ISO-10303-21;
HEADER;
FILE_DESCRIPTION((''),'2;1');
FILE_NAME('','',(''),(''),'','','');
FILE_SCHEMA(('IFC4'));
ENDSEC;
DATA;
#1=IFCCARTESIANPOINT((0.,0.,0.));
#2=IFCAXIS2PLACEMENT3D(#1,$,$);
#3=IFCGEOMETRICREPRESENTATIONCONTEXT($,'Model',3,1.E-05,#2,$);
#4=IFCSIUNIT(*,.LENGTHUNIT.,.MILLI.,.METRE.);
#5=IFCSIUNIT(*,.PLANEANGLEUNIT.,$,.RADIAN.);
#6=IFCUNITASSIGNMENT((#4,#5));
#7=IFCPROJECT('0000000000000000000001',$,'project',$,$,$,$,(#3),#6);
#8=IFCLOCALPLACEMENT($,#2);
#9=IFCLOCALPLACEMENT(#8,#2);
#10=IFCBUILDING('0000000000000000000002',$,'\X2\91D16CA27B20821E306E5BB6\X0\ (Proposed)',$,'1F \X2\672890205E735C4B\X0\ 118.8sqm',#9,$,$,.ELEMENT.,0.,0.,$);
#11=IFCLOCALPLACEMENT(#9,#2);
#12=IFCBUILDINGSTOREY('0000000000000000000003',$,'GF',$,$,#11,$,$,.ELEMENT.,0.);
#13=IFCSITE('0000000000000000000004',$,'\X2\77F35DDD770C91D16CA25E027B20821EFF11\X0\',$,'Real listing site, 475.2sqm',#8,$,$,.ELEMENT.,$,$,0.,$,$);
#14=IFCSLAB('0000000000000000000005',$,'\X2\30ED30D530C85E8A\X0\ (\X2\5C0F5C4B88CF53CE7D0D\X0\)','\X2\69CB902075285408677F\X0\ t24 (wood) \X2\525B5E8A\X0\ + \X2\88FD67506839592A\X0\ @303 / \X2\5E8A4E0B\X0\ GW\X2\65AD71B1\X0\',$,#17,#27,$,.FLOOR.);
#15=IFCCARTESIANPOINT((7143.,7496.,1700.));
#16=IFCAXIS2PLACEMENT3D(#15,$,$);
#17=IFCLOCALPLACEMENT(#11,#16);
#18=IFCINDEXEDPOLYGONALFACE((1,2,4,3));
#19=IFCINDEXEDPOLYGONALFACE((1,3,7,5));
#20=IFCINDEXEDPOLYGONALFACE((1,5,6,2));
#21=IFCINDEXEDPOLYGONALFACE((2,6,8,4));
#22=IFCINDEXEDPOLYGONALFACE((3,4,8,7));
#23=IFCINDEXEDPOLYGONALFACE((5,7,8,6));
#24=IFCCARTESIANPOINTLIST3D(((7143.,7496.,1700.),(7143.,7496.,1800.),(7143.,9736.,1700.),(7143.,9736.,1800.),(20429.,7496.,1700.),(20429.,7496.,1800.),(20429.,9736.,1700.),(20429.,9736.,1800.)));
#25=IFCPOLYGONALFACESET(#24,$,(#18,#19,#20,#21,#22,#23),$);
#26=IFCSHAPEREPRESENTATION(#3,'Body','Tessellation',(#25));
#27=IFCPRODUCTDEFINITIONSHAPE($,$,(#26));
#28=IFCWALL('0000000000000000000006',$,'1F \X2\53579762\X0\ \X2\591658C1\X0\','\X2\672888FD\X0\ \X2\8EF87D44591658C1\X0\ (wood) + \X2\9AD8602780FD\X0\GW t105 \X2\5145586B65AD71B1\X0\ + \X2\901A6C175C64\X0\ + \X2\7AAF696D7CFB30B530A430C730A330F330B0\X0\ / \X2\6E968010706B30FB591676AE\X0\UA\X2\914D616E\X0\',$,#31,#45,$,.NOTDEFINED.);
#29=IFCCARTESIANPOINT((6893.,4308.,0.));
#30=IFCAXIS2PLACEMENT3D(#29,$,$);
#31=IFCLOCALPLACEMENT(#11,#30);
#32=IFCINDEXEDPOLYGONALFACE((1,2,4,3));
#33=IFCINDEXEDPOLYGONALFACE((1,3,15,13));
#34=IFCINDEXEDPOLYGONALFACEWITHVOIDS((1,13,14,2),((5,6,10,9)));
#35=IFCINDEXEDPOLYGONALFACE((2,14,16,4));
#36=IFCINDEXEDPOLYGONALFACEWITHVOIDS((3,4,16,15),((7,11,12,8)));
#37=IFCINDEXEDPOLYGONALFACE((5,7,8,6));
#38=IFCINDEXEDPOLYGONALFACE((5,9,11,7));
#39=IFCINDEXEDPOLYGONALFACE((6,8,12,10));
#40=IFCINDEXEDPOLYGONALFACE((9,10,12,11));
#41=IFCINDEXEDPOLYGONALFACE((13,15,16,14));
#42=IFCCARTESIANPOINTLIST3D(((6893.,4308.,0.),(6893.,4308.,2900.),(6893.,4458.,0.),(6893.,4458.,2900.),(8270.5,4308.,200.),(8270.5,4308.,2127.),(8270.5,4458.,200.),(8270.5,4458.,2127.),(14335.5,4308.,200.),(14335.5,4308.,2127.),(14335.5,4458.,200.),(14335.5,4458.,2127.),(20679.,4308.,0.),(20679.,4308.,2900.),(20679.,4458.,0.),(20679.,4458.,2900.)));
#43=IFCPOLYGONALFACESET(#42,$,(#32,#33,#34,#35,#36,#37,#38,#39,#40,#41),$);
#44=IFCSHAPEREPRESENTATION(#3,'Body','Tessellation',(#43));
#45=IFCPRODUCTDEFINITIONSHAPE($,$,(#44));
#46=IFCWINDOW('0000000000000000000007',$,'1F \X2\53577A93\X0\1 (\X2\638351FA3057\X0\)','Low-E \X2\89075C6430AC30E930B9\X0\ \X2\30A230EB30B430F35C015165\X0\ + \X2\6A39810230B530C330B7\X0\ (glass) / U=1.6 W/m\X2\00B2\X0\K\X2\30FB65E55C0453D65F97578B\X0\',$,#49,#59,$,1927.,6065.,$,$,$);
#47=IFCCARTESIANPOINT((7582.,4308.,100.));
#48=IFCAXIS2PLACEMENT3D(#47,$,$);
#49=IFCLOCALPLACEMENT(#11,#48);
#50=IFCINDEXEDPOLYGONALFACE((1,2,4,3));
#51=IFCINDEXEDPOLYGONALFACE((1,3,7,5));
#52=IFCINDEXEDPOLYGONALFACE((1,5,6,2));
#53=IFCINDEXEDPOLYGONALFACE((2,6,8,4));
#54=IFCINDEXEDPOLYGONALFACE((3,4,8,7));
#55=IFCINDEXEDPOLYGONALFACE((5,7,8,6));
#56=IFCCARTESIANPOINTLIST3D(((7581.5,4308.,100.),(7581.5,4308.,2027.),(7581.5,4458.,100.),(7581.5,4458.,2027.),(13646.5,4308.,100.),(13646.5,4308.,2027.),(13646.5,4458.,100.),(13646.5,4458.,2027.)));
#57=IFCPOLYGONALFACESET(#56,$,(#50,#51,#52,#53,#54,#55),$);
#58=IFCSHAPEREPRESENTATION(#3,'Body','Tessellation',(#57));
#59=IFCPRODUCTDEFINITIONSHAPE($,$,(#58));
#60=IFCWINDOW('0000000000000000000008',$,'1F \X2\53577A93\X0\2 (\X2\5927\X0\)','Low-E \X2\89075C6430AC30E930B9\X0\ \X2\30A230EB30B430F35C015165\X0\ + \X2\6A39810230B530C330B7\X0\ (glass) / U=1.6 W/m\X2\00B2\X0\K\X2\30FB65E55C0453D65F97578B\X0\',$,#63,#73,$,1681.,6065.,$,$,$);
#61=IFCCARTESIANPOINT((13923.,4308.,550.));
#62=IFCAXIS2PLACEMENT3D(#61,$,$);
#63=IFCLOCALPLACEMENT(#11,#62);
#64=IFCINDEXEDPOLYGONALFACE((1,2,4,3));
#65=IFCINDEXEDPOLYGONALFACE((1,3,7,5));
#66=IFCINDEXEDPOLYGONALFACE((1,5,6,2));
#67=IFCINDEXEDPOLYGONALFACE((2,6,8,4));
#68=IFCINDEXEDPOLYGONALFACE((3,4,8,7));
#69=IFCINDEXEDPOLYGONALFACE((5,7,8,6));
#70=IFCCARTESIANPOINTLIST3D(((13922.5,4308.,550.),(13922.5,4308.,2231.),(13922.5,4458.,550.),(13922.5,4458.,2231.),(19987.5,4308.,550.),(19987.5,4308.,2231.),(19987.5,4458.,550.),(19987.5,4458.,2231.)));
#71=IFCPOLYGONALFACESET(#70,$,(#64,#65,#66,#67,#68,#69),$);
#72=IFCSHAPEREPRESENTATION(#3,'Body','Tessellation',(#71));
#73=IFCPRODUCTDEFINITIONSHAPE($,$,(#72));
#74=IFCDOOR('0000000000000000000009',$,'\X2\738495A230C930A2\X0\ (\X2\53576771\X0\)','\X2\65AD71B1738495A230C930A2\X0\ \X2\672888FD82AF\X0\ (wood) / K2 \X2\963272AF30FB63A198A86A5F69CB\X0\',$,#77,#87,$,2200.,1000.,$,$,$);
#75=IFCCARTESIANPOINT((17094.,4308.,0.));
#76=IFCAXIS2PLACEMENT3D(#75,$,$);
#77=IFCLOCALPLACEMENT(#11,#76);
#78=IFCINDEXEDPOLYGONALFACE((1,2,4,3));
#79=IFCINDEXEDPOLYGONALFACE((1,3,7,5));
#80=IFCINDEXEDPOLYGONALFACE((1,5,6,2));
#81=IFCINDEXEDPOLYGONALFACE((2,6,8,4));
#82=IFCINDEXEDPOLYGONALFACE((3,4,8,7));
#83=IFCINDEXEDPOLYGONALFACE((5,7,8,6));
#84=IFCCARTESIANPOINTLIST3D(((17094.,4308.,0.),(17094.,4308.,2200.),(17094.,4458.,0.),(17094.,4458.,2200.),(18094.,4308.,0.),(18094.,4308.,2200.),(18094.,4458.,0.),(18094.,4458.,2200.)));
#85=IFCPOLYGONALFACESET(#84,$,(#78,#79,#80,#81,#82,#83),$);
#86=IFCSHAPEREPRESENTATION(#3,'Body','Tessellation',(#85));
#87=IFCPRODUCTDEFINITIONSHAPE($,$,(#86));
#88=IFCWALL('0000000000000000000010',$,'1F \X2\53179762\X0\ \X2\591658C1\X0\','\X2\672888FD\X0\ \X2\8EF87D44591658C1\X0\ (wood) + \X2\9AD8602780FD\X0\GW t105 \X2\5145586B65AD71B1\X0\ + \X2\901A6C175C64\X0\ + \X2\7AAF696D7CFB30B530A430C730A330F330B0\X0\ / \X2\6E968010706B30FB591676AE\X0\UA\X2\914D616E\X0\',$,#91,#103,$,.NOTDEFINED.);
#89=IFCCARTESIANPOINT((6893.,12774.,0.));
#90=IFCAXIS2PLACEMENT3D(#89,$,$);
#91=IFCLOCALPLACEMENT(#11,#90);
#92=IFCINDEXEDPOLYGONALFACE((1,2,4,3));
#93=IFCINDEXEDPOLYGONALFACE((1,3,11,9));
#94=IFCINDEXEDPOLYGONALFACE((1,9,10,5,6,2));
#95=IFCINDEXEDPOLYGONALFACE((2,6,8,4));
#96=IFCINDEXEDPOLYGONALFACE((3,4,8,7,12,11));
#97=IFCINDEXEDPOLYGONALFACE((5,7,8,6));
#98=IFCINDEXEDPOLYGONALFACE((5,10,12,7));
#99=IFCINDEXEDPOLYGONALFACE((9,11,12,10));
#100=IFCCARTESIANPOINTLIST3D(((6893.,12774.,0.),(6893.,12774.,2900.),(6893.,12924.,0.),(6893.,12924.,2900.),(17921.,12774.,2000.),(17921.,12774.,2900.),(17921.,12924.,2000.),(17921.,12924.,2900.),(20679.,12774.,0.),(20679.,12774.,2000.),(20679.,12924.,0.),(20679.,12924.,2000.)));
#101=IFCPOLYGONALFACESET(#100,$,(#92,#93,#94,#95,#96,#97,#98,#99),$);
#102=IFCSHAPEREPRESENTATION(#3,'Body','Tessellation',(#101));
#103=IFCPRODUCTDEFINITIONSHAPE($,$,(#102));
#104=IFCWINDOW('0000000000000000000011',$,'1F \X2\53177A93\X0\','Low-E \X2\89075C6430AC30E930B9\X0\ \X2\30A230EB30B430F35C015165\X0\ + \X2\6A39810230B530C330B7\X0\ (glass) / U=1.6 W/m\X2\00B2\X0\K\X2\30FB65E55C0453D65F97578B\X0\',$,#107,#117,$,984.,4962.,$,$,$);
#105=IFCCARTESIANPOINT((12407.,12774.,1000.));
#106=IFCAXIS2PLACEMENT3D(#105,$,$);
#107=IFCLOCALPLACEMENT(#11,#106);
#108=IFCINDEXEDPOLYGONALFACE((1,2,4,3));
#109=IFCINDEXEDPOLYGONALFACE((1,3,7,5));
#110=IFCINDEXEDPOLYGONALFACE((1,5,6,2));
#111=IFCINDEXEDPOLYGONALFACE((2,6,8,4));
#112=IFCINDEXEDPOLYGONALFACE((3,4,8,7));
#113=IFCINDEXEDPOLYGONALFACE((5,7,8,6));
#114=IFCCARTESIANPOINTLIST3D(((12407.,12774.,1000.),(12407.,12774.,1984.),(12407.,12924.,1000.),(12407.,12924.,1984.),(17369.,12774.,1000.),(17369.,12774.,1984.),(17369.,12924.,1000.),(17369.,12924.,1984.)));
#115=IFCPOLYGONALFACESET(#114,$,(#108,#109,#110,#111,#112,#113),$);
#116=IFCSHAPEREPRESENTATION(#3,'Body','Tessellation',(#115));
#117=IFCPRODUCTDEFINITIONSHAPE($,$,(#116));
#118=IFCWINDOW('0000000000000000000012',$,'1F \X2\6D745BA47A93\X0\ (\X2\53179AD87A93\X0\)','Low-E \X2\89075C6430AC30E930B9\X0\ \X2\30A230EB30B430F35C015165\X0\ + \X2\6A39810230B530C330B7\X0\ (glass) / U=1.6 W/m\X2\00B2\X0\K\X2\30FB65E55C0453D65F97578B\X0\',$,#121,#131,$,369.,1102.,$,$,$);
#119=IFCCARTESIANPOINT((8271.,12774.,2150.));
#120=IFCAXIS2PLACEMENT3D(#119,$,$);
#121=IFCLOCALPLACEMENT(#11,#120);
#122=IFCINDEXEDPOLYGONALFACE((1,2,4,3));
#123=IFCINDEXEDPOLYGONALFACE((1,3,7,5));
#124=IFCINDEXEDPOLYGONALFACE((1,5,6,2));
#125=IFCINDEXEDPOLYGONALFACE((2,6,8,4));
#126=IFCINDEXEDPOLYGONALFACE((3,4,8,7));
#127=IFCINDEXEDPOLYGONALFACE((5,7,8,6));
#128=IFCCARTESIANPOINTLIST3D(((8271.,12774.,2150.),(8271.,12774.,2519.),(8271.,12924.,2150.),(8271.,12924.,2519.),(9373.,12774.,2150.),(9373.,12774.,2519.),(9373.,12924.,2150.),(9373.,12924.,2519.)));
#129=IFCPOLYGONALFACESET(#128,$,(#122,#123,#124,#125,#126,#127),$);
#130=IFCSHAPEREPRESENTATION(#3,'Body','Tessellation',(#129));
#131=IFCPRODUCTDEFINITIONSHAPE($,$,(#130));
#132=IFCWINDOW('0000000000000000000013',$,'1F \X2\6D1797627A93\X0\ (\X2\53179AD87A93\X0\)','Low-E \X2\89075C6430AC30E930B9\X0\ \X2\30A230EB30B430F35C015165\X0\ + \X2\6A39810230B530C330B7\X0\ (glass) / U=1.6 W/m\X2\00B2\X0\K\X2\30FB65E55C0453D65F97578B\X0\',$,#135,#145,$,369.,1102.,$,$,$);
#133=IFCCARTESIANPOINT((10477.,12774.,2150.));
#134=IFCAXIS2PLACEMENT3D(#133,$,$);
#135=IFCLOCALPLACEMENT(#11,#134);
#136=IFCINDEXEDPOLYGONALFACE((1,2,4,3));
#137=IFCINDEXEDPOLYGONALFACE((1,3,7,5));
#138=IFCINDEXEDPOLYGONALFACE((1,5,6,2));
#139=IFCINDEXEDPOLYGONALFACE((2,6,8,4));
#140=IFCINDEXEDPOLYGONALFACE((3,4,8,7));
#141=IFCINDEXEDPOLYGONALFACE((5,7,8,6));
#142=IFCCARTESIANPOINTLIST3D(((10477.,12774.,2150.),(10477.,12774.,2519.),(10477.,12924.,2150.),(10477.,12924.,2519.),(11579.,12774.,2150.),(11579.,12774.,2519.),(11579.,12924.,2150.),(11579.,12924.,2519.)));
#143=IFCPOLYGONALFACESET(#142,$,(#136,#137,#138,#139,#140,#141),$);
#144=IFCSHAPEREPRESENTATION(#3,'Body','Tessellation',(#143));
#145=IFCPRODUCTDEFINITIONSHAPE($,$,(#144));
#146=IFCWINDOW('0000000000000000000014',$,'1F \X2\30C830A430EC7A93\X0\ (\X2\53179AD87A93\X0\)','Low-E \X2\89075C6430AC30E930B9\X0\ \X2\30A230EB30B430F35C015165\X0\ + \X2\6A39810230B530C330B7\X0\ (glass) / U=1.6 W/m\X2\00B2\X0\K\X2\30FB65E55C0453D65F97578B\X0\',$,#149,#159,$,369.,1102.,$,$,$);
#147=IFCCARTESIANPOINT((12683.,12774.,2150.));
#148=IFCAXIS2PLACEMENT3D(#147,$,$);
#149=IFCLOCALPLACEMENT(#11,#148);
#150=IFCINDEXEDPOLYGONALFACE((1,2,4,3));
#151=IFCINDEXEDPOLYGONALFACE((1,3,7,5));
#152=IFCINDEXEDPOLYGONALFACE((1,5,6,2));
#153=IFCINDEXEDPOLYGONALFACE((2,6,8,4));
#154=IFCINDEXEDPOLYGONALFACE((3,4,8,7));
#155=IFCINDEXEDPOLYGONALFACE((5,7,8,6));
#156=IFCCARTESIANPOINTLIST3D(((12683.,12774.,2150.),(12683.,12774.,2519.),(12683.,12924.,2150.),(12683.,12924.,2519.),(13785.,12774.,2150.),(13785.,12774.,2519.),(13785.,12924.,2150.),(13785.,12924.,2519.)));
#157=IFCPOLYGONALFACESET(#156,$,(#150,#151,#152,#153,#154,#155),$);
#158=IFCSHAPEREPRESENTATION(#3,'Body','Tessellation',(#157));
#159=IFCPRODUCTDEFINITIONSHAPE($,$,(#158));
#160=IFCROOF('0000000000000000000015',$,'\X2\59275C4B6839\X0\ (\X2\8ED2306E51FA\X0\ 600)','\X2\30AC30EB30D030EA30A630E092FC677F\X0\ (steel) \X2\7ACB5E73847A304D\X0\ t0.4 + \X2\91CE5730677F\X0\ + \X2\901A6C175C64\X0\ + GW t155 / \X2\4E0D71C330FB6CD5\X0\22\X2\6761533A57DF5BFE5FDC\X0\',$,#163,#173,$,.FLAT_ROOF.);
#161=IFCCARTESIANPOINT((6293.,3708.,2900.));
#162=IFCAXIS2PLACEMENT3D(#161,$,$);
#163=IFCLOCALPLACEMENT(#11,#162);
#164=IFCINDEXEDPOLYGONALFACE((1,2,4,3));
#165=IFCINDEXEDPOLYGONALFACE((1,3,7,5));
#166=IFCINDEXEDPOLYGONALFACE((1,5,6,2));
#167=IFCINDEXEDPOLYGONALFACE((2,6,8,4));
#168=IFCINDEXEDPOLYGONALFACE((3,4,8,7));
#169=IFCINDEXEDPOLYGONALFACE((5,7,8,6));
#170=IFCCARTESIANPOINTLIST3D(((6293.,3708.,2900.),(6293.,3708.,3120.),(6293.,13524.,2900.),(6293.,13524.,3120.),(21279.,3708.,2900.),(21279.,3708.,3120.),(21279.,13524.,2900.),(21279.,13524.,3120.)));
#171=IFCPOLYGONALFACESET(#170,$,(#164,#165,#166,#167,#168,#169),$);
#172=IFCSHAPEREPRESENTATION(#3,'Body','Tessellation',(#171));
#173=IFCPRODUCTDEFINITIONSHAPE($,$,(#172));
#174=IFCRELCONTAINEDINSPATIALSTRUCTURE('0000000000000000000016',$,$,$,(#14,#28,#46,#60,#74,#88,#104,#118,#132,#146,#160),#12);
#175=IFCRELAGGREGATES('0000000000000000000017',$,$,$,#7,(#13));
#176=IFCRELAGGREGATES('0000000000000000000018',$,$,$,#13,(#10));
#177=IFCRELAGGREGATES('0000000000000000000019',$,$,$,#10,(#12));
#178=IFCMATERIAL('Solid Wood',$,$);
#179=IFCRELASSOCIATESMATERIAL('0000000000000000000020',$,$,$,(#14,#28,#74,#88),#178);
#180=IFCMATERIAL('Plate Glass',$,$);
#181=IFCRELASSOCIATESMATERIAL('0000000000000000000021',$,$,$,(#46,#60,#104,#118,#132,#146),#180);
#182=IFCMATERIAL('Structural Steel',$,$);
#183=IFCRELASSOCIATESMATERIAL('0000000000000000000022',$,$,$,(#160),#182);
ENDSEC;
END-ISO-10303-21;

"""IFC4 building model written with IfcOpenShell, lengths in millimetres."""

from ifc_helpers import new_model, si_unit, frame, frame_2d, origin, place, context, project, spatial, rectangle, extrude, material, element, fill, save


model = new_model("IFC4")

# Units and contexts
model_context = context("Model", 3, precision=1e-05, world=origin())
ifc_project = project(units=[si_unit("LENGTHUNIT", "METRE", prefix="MILLI"), si_unit("PLANEANGLEUNIT", "RADIAN")], contexts=[model_context])

# Site, building, storey
site_placement = place(None, origin())
site = spatial("IfcSite", under=ifc_project, at=site_placement, Name="石川県金沢市笠舞１", ObjectType="Real listing site, 475.2sqm", CompositionType="ELEMENT", RefElevation=0.0)
building_placement = place(site_placement, origin())
building = spatial("IfcBuilding", under=site, at=building_placement, Name="金沢笠舞の家 (Proposed)", ObjectType="1F 木造平屋 118.8sqm", CompositionType="ELEMENT", ElevationOfRefHeight=0.0, ElevationOfTerrain=0.0)
storey_placement = place(building_placement, origin())
storey = spatial("IfcBuildingStorey", under=building, at=storey_placement, Name="GF", CompositionType="ELEMENT", Elevation=0.0)

# Slab
ifc_material_1 = material(Name="Solid Wood")
slab_1_placement = place(storey_placement, frame((7143.0, 7496.0, 1700.0)))
element("IfcSlab", 1, at=slab_1_placement, inside=storey, material=ifc_material_1, Name="ロフト床 (小屋裏収納)", Description="構造用合板 t24 (wood) 剛床 + 製材根太 @303 / 床下 GW断熱", PredefinedType="FLOOR", context=model_context, shape_type="SweptSolid", body=[
    extrude(rectangle(XDim=13286.0, YDim=2240.0, at=frame_2d((6643.0, 1120.0))), frame((7143.0, 7496.0, 1700.0)), (0.0, 0.0, 1.0), 100.0),
])

# Wall, openings, windows, door
wall_1_placement = place(storey_placement, frame((6893.0, 4308.0, 0.0)))
wall_1 = element("IfcWall", 2, at=wall_1_placement, inside=storey, material=ifc_material_1, Name="1F 南面 外壁", Description="木製 軸組外壁 (wood) + 高性能GW t105 充填断熱 + 通気層 + 窯業系サイディング / 準耐火・外皮UA配慮", PredefinedType="NOTDEFINED", context=model_context, shape_type="SweptSolid", body=[
    extrude(rectangle(XDim=13786.0, YDim=150.0, at=frame_2d((6893.0, 75.0))), frame((6893.0, 4308.0, 0.0)), (0.0, 0.0, 1.0), 2900.0),
])
opening_1_placement = place(storey_placement, frame((7582.0, 4308.0, 100.0)))
opening_1 = element("IfcOpeningElement", 3, at=opening_1_placement, cuts=wall_1, PredefinedType="NOTDEFINED", context=model_context, shape_type="SweptSolid", body=[
    extrude(rectangle(XDim=6065.0, YDim=150.0, at=frame_2d((3032.0, 75.0))), frame((7582.0, 4308.0, 100.0)), (0.0, 0.0, 1.0), 1927.0),
])
opening_2_placement = place(storey_placement, frame((13923.0, 4308.0, 550.0)))
opening_2 = element("IfcOpeningElement", 4, at=opening_2_placement, cuts=wall_1, PredefinedType="NOTDEFINED", context=model_context, shape_type="SweptSolid", body=[
    extrude(rectangle(XDim=6065.0, YDim=150.0, at=frame_2d((3032.0, 75.0))), frame((13923.0, 4308.0, 550.0)), (0.0, 0.0, 1.0), 1681.0),
])
opening_3_placement = place(storey_placement, frame((17094.0, 4308.0, 0.0)))
opening_3 = element("IfcOpeningElement", 5, at=opening_3_placement, cuts=wall_1, PredefinedType="NOTDEFINED", context=model_context, shape_type="SweptSolid", body=[
    extrude(rectangle(XDim=1000.0, YDim=150.0, at=frame_2d((500.0, 75.0))), frame((17094.0, 4308.0, 0.0)), (0.0, 0.0, 1.0), 2200.0),
])
ifc_material_2 = material(Name="Plate Glass")
window_1_placement = place(storey_placement, frame((7582.0, 4308.0, 100.0)))
window_1 = element("IfcWindow", 6, at=window_1_placement, inside=storey, material=ifc_material_2, Name="1F 南窓1 (掃出し)", Description="Low-E 複層ガラス アルゴン封入 + 樹脂サッシ (glass) / U=1.6 W/m²K・日射取得型", OverallHeight=1927.0, OverallWidth=6065.0, context=model_context, shape_type="SweptSolid", body=[
    extrude(rectangle(XDim=6065.0, YDim=150.0, at=frame_2d((3032.0, 75.0))), frame((7582.0, 4308.0, 100.0)), (0.0, 0.0, 1.0), 1927.0),
])
fill(opening_1, window_1)
window_2_placement = place(storey_placement, frame((13923.0, 4308.0, 550.0)))
window_2 = element("IfcWindow", 7, at=window_2_placement, inside=storey, material=ifc_material_2, Name="1F 南窓2 (大)", Description="Low-E 複層ガラス アルゴン封入 + 樹脂サッシ (glass) / U=1.6 W/m²K・日射取得型", OverallHeight=1681.0, OverallWidth=6065.0, context=model_context, shape_type="SweptSolid", body=[
    extrude(rectangle(XDim=6065.0, YDim=150.0, at=frame_2d((3032.0, 75.0))), frame((13923.0, 4308.0, 550.0)), (0.0, 0.0, 1.0), 1681.0),
])
fill(opening_2, window_2)
door_1_placement = place(storey_placement, frame((17094.0, 4308.0, 0.0)))
door_1 = element("IfcDoor", 8, at=door_1_placement, inside=storey, material=ifc_material_1, Name="玄関ドア (南東)", Description="断熱玄関ドア 木製芯 (wood) / K2 防犯・採風機構", OverallHeight=2200.0, OverallWidth=1000.0, context=model_context, shape_type="SweptSolid", body=[
    extrude(rectangle(XDim=1000.0, YDim=150.0, at=frame_2d((500.0, 75.0))), frame((17094.0, 4308.0, 0.0)), (0.0, 0.0, 1.0), 2200.0),
])
fill(opening_3, door_1)

# Wall, openings, windows
wall_2_placement = place(storey_placement, frame((6893.0, 12774.0, 0.0)))
wall_2 = element("IfcWall", 9, at=wall_2_placement, inside=storey, material=ifc_material_1, Name="1F 北面 外壁", Description="木製 軸組外壁 (wood) + 高性能GW t105 充填断熱 + 通気層 + 窯業系サイディング / 準耐火・外皮UA配慮", PredefinedType="NOTDEFINED", context=model_context, shape_type="SweptSolid", body=[
    extrude(rectangle(XDim=13786.0, YDim=150.0, at=frame_2d((6893.0, 75.0))), frame((6893.0, 12774.0, 0.0)), (0.0, 0.0, 1.0), 2900.0),
])
opening_4_placement = place(storey_placement, frame((12407.0, 12774.0, 1000.0)))
opening_4 = element("IfcOpeningElement", 10, at=opening_4_placement, cuts=wall_2, PredefinedType="NOTDEFINED", context=model_context, shape_type="SweptSolid", body=[
    extrude(rectangle(XDim=4962.0, YDim=150.0, at=frame_2d((2481.0, 75.0))), frame((12407.0, 12774.0, 1000.0)), (0.0, 0.0, 1.0), 984.0),
])
opening_5_placement = place(storey_placement, frame((8271.0, 12774.0, 2150.0)))
opening_5 = element("IfcOpeningElement", 11, at=opening_5_placement, cuts=wall_2, PredefinedType="NOTDEFINED", context=model_context, shape_type="SweptSolid", body=[
    extrude(rectangle(XDim=1102.0, YDim=150.0, at=frame_2d((551.0, 75.0))), frame((8271.0, 12774.0, 2150.0)), (0.0, 0.0, 1.0), 369.0),
])
opening_6_placement = place(storey_placement, frame((10477.0, 12774.0, 2150.0)))
opening_6 = element("IfcOpeningElement", 12, at=opening_6_placement, cuts=wall_2, PredefinedType="NOTDEFINED", context=model_context, shape_type="SweptSolid", body=[
    extrude(rectangle(XDim=1102.0, YDim=150.0, at=frame_2d((551.0, 75.0))), frame((10477.0, 12774.0, 2150.0)), (0.0, 0.0, 1.0), 369.0),
])
opening_7_placement = place(storey_placement, frame((12683.0, 12774.0, 2150.0)))
opening_7 = element("IfcOpeningElement", 13, at=opening_7_placement, cuts=wall_2, PredefinedType="NOTDEFINED", context=model_context, shape_type="SweptSolid", body=[
    extrude(rectangle(XDim=1102.0, YDim=150.0, at=frame_2d((551.0, 75.0))), frame((12683.0, 12774.0, 2150.0)), (0.0, 0.0, 1.0), 369.0),
])
window_3_placement = place(storey_placement, frame((12407.0, 12774.0, 1000.0)))
window_3 = element("IfcWindow", 14, at=window_3_placement, inside=storey, material=ifc_material_2, Name="1F 北窓", Description="Low-E 複層ガラス アルゴン封入 + 樹脂サッシ (glass) / U=1.6 W/m²K・日射取得型", OverallHeight=984.0, OverallWidth=4962.0, context=model_context, shape_type="SweptSolid", body=[
    extrude(rectangle(XDim=4962.0, YDim=150.0, at=frame_2d((2481.0, 75.0))), frame((12407.0, 12774.0, 1000.0)), (0.0, 0.0, 1.0), 984.0),
])
fill(opening_4, window_3)
window_4_placement = place(storey_placement, frame((8271.0, 12774.0, 2150.0)))
window_4 = element("IfcWindow", 15, at=window_4_placement, inside=storey, material=ifc_material_2, Name="1F 浴室窓 (北高窓)", Description="Low-E 複層ガラス アルゴン封入 + 樹脂サッシ (glass) / U=1.6 W/m²K・日射取得型", OverallHeight=369.0, OverallWidth=1102.0, context=model_context, shape_type="SweptSolid", body=[
    extrude(rectangle(XDim=1102.0, YDim=150.0, at=frame_2d((551.0, 75.0))), frame((8271.0, 12774.0, 2150.0)), (0.0, 0.0, 1.0), 369.0),
])
fill(opening_5, window_4)
window_5_placement = place(storey_placement, frame((10477.0, 12774.0, 2150.0)))
window_5 = element("IfcWindow", 16, at=window_5_placement, inside=storey, material=ifc_material_2, Name="1F 洗面窓 (北高窓)", Description="Low-E 複層ガラス アルゴン封入 + 樹脂サッシ (glass) / U=1.6 W/m²K・日射取得型", OverallHeight=369.0, OverallWidth=1102.0, context=model_context, shape_type="SweptSolid", body=[
    extrude(rectangle(XDim=1102.0, YDim=150.0, at=frame_2d((551.0, 75.0))), frame((10477.0, 12774.0, 2150.0)), (0.0, 0.0, 1.0), 369.0),
])
fill(opening_6, window_5)
window_6_placement = place(storey_placement, frame((12683.0, 12774.0, 2150.0)))
window_6 = element("IfcWindow", 17, at=window_6_placement, inside=storey, material=ifc_material_2, Name="1F トイレ窓 (北高窓)", Description="Low-E 複層ガラス アルゴン封入 + 樹脂サッシ (glass) / U=1.6 W/m²K・日射取得型", OverallHeight=369.0, OverallWidth=1102.0, context=model_context, shape_type="SweptSolid", body=[
    extrude(rectangle(XDim=1102.0, YDim=150.0, at=frame_2d((551.0, 75.0))), frame((12683.0, 12774.0, 2150.0)), (0.0, 0.0, 1.0), 369.0),
])
fill(opening_7, window_6)

# Roof
ifc_material_3 = material(Name="Structural Steel")
roof_placement = place(storey_placement, frame((6293.0, 3708.0, 2900.0)))
element("IfcRoof", 18, at=roof_placement, inside=storey, material=ifc_material_3, Name="大屋根 (軒の出 600)", Description="ガルバリウム鋼板 (steel) 立平葺き t0.4 + 野地板 + 通気層 + GW t155 / 不燃・法22条区域対応", PredefinedType="FLAT_ROOF", context=model_context, shape_type="SweptSolid", body=[
    extrude(rectangle(XDim=14986.0, YDim=9816.0, at=frame_2d((7493.0, 4908.0))), frame((6293.0, 3708.0, 2900.0)), (0.0, 0.0, 1.0), 220.0),
])

save(model, "model.ifc")
